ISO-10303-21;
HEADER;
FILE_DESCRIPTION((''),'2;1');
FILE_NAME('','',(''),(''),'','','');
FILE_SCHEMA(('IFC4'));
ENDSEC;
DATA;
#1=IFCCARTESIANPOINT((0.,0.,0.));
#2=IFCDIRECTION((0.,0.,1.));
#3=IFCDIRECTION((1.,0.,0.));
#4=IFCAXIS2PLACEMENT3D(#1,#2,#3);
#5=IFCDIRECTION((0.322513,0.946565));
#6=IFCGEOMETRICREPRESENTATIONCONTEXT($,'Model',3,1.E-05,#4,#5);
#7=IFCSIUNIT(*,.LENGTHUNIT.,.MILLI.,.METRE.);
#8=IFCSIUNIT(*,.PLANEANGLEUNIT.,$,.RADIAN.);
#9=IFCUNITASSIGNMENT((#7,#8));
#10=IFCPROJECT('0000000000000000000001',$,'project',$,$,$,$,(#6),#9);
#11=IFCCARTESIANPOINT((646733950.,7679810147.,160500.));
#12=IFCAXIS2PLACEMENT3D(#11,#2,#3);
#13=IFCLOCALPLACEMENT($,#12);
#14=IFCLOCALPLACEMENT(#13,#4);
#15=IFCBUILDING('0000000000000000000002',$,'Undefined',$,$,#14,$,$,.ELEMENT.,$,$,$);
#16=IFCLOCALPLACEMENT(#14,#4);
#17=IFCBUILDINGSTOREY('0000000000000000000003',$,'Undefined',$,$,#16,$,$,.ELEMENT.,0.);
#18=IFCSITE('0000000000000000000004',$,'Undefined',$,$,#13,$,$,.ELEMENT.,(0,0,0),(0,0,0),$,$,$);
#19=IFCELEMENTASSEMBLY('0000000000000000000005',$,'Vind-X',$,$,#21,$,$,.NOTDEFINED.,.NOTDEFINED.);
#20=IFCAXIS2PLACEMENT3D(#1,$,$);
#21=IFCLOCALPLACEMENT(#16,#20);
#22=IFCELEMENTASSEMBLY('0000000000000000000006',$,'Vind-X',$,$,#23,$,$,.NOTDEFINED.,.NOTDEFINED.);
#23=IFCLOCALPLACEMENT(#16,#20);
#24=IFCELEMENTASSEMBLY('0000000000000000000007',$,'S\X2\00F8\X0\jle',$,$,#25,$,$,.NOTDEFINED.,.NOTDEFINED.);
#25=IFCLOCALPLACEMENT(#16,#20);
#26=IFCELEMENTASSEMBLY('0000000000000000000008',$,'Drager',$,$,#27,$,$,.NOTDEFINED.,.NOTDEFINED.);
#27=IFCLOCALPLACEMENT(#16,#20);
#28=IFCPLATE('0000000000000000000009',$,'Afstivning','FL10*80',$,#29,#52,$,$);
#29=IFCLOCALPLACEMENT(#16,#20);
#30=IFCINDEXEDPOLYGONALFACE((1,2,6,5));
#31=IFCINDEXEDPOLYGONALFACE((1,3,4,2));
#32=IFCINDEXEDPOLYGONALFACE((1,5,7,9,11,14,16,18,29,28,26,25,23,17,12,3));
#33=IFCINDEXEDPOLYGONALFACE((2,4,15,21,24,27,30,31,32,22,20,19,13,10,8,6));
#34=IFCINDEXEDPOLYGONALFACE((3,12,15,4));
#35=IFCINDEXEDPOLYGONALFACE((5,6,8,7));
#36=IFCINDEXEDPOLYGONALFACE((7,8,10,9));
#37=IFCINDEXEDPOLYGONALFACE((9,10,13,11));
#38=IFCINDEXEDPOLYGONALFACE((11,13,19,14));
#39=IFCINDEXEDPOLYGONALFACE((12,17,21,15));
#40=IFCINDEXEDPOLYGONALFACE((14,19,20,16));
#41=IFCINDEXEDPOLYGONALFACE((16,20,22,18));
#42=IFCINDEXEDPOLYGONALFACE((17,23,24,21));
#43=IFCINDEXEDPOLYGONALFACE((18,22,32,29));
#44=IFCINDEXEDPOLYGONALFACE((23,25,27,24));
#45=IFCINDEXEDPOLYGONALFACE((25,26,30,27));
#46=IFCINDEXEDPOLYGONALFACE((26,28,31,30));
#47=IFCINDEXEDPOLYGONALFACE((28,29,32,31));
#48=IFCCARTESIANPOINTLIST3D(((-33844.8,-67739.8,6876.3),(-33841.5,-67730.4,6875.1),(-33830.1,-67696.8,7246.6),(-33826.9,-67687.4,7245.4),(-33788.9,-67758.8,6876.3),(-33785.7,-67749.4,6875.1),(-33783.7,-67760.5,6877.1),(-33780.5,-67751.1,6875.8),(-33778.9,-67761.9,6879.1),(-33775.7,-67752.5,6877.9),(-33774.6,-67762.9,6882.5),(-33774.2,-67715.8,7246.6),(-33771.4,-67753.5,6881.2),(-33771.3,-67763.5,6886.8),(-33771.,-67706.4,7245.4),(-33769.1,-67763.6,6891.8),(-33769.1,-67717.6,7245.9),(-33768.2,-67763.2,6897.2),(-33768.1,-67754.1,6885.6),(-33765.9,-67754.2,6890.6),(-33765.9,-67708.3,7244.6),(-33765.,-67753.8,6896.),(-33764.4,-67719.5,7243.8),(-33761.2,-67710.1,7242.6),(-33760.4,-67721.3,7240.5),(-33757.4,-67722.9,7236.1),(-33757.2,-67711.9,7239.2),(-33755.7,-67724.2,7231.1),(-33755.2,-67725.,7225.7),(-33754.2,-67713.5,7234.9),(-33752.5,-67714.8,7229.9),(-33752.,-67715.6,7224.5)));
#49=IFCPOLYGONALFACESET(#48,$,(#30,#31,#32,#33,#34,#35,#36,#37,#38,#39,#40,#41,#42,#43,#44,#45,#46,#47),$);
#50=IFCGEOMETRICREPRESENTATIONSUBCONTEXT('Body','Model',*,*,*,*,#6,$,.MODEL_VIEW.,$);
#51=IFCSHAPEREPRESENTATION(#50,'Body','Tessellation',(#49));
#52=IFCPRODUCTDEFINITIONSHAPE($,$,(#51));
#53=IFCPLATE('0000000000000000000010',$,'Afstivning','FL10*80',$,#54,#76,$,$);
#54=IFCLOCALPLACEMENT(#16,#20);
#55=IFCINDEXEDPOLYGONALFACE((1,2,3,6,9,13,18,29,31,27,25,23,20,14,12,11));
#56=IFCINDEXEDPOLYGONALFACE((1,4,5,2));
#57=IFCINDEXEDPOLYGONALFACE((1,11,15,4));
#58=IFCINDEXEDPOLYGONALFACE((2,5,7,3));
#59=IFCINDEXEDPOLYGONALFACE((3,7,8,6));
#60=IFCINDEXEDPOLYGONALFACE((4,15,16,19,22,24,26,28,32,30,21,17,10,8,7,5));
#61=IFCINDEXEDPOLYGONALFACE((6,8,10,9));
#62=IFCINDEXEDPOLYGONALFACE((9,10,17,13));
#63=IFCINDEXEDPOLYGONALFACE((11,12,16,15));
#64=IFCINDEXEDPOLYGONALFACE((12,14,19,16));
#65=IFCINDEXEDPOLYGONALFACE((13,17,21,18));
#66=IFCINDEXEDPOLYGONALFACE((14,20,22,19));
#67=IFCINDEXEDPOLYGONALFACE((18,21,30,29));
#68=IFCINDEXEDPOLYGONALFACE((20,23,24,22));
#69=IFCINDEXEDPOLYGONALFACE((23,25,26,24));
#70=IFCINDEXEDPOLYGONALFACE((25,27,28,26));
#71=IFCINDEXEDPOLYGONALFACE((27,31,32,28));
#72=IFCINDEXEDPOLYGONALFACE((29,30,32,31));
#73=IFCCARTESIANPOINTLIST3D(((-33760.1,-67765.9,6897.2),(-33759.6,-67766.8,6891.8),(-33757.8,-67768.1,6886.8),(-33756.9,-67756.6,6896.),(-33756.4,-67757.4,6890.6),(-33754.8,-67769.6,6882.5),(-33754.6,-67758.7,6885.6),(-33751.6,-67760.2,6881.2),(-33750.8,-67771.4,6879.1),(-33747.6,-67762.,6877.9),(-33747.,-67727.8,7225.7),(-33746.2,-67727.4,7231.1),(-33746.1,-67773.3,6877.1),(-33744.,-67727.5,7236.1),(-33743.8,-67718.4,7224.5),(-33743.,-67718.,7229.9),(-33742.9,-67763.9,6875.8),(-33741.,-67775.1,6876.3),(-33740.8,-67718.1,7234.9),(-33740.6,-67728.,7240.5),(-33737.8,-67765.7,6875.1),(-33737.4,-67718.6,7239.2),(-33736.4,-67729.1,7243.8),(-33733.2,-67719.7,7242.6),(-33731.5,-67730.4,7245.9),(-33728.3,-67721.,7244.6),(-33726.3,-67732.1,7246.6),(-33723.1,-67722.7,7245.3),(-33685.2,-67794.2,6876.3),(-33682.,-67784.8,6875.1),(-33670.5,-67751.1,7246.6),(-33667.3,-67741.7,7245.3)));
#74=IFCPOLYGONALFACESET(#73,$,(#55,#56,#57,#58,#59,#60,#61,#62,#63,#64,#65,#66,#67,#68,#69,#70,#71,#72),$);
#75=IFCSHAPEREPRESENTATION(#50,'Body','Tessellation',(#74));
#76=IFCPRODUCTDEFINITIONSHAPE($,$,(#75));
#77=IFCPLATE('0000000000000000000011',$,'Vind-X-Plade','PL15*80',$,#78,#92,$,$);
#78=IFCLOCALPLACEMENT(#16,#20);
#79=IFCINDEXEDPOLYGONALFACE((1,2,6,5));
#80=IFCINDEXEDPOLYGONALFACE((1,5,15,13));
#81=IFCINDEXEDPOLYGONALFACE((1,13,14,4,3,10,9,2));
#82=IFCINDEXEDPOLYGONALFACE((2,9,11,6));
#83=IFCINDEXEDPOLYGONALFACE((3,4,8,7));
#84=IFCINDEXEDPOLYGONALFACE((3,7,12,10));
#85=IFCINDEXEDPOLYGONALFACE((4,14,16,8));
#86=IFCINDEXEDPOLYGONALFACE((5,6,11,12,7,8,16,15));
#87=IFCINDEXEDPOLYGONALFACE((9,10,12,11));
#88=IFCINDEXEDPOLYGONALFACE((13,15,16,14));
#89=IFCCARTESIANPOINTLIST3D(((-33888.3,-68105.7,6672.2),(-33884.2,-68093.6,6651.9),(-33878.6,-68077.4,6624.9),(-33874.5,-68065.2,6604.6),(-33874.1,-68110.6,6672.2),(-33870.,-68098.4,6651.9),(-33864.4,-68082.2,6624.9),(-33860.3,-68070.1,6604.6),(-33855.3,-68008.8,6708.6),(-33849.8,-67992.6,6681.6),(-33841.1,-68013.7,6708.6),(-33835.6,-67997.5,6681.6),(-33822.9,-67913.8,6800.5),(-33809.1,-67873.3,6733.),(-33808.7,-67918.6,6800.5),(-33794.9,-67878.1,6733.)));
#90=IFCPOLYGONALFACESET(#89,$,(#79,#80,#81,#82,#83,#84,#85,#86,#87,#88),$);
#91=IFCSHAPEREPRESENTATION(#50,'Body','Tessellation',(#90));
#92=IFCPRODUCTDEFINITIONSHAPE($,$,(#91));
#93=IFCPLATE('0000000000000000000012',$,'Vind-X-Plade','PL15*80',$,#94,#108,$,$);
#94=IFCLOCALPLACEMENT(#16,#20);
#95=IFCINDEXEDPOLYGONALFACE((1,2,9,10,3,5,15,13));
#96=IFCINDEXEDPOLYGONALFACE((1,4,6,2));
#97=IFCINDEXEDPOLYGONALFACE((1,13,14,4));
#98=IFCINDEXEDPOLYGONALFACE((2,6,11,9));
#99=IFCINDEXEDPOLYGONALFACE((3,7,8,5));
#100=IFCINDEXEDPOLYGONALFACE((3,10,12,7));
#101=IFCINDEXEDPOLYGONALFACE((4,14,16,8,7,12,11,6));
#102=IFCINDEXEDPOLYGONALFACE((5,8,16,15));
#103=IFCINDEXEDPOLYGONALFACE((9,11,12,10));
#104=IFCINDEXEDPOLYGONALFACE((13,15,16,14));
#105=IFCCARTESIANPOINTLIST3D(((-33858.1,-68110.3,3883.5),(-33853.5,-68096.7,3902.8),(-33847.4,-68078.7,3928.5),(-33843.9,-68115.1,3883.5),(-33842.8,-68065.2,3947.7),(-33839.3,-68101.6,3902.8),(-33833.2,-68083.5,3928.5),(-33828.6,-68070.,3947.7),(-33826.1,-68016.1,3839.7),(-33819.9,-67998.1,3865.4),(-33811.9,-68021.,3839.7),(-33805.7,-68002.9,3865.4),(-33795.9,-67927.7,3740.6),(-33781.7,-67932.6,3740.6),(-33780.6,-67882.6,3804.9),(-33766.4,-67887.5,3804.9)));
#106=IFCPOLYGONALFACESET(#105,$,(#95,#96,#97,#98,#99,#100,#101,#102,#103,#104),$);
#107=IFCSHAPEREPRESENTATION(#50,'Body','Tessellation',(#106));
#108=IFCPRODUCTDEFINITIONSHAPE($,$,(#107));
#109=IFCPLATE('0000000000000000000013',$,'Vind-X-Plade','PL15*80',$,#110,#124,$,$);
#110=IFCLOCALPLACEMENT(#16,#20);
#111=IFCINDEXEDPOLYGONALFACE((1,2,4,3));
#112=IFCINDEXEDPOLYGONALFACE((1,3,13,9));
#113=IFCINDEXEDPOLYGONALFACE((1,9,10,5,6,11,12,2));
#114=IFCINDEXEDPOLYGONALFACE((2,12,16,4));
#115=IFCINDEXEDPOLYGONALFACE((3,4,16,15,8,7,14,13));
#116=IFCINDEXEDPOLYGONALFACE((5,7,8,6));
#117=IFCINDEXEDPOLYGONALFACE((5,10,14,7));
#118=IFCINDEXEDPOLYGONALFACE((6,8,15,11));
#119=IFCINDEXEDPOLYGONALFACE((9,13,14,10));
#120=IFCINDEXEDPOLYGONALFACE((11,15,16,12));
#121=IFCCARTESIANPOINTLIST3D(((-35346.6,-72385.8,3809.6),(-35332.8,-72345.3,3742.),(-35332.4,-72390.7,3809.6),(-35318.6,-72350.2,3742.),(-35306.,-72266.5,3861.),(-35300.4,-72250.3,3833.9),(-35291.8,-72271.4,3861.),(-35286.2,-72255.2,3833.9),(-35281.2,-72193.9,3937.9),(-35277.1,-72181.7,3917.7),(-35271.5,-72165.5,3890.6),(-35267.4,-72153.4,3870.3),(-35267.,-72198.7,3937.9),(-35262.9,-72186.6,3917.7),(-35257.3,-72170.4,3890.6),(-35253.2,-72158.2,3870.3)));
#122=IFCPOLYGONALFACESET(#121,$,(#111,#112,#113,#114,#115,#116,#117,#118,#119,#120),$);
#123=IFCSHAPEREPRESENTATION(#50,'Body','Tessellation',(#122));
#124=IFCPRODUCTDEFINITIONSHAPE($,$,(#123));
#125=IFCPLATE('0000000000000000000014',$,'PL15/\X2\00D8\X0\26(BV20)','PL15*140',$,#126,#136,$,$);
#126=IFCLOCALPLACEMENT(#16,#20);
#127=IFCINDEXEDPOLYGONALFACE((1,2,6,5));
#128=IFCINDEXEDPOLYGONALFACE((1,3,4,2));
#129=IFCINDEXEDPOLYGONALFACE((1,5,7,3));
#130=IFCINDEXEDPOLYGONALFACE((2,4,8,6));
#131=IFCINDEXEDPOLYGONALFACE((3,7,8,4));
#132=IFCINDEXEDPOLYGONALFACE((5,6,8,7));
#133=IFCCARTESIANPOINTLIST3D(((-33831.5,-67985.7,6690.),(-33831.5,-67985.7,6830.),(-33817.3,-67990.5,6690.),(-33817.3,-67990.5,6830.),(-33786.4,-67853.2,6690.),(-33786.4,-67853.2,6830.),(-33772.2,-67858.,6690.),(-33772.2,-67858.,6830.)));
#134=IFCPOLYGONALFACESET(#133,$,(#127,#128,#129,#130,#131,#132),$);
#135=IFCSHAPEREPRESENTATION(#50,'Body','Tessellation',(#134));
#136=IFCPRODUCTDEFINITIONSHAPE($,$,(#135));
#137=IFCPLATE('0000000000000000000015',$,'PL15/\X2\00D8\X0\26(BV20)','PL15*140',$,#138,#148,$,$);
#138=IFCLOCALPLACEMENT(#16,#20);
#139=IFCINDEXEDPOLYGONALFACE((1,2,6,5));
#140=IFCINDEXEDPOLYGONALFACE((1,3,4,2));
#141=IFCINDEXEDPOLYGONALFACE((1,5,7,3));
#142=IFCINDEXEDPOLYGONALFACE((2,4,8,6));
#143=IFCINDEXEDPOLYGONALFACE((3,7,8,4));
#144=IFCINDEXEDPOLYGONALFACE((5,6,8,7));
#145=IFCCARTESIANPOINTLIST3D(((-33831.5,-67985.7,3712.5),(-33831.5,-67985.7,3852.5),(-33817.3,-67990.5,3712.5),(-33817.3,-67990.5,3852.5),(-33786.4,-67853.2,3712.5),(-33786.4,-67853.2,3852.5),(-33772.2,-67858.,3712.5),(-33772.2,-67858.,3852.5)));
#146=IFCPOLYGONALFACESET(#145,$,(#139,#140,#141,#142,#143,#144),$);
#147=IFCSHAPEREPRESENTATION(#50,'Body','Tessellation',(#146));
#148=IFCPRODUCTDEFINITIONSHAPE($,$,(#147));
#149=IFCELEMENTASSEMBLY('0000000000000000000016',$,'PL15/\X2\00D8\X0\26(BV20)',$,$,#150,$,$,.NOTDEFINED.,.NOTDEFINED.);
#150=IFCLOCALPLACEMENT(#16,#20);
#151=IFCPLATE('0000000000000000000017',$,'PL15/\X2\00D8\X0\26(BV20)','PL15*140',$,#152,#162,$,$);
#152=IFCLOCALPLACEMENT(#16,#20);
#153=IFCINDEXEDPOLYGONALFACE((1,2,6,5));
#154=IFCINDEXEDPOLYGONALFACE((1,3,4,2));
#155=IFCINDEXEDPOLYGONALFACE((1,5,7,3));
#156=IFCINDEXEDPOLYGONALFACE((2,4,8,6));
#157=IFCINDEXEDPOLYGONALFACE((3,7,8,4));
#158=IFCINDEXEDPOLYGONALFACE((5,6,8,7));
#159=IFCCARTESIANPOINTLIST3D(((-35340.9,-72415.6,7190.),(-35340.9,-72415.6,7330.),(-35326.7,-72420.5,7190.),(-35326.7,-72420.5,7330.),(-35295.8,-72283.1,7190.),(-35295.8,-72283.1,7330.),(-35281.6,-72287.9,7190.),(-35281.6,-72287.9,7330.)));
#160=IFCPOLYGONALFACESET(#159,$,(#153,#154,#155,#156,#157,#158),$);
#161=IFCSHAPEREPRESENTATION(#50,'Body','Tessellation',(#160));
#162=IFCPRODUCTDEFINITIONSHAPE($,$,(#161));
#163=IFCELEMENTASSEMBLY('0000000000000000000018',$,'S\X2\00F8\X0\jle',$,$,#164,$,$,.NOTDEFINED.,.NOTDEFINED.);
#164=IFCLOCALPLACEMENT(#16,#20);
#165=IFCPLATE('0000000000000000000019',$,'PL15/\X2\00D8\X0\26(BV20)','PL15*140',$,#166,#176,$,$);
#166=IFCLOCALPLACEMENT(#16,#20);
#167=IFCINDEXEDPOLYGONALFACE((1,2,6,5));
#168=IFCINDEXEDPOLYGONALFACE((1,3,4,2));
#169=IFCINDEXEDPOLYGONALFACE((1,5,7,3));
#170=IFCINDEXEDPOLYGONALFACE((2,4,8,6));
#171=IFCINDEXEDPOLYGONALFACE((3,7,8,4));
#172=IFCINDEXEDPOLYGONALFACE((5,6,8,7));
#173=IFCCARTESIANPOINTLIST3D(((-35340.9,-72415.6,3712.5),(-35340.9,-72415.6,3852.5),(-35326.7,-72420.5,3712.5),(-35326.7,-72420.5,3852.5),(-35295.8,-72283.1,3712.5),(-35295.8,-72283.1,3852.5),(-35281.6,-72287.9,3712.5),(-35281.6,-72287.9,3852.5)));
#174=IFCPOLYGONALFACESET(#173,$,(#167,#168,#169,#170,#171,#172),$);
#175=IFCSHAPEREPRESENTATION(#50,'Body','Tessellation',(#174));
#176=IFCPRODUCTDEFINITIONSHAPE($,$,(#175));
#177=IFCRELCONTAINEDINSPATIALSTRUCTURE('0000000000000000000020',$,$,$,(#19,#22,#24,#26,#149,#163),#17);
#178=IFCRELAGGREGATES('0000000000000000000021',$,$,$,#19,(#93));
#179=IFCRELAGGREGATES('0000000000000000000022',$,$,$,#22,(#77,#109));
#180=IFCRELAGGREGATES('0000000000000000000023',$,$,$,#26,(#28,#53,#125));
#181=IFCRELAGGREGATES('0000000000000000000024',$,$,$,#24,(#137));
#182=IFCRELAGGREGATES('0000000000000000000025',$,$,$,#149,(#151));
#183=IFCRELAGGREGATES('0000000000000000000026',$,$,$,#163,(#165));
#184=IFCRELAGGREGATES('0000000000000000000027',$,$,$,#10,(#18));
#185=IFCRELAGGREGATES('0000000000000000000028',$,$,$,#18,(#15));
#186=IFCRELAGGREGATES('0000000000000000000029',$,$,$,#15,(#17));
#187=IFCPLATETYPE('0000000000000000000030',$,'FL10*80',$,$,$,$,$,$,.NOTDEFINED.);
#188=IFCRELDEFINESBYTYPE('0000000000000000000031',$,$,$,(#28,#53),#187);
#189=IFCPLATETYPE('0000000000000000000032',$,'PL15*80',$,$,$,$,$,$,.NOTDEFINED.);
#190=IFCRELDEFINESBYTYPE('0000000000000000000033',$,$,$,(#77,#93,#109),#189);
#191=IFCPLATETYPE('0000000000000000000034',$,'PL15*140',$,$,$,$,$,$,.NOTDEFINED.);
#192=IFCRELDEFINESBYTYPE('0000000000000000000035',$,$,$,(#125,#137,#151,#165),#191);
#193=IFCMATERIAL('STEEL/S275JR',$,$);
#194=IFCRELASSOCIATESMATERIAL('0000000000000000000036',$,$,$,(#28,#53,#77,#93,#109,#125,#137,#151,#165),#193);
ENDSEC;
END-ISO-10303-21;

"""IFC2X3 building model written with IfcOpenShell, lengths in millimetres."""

from ifc_helpers import new_model, si_unit, direction, frame, frame_2d, origin_with_axes, place, context, subcontext, project, spatial, polyline, circle_curve, parameter, trimmed, segment, composite_curve, outline, extrude, boolean, material, type_object, element, aggregate, save


model = new_model("IFC2X3")

# Units and contexts
model_context = context("Model", 3, precision=1e-05, world=origin_with_axes(), true_north=direction((0.322513, 0.946565)))
body_context = subcontext(model_context, "Body", "Model", "MODEL_VIEW")
ifc_project = project(units=[si_unit("LENGTHUNIT", "METRE", prefix="MILLI"), si_unit("PLANEANGLEUNIT", "RADIAN")], contexts=[model_context])

# Site, building, storey
site_placement = place(None, frame((646733950.0, 7679810147.0, 160500.0), z_axis=(0.0, 0.0, 1.0), x_axis=(1.0, 0.0, 0.0)))
site = spatial("IfcSite", under=ifc_project, at=site_placement, Name="Undefined", CompositionType="ELEMENT", RefLatitude=(0, 0, 0), RefLongitude=(0, 0, 0))
building_placement = place(site_placement, origin_with_axes())
building = spatial("IfcBuilding", under=site, at=building_placement, Name="Undefined", CompositionType="ELEMENT")
storey_placement = place(building_placement, origin_with_axes())
storey = spatial("IfcBuildingStorey", under=building, at=storey_placement, Name="Undefined", CompositionType="ELEMENT", Elevation=0.0)

# Element assemblies
assembly_1_placement = place(storey_placement, origin_with_axes())
assembly_1 = element("IfcElementAssembly", 1, at=assembly_1_placement, inside=storey, Name="Vind-X", AssemblyPlace="NOTDEFINED", PredefinedType="NOTDEFINED")
assembly_2_placement = place(storey_placement, origin_with_axes())
assembly_2 = element("IfcElementAssembly", 2, at=assembly_2_placement, inside=storey, Name="Vind-X", AssemblyPlace="NOTDEFINED", PredefinedType="NOTDEFINED")

# Element assembly
assembly_3_placement = place(storey_placement, origin_with_axes())
assembly_3 = element("IfcElementAssembly", 3, at=assembly_3_placement, inside=storey, Name="Søjle", AssemblyPlace="NOTDEFINED", PredefinedType="NOTDEFINED")
ifc_material_1 = material(Name="STEEL/S275JR")

# Element assembly, plates
assembly_4_placement = place(storey_placement, origin_with_axes())
assembly_4 = element("IfcElementAssembly", 4, at=assembly_4_placement, inside=storey, Name="Drager", AssemblyPlace="NOTDEFINED", PredefinedType="NOTDEFINED")
plate_type_1 = type_object("IfcPlateType", Name="FL10*80", PredefinedType="NOTDEFINED")
plate_1_placement = place(assembly_4_placement, frame((-33767.4, -67760.9, 6875.7), z_axis=(0.320109, 0.93951, -0.121869), x_axis=(-0.946565, 0.322513, 0.0)))
plate_1 = element("IfcPlate", 5, at=plate_1_placement, type_object=plate_type_1, material=ifc_material_1, Name="Afstivning", Description="FL10*80", context=body_context, shape_type="SweptSolid", body=[
    extrude(outline(composite_curve([segment(trimmed(circle_curve(frame_2d((21.0, 21.0), x_axis=(-1.0, 0.0)), 21.0), [parameter(0.0)], [parameter(1.570796)], True, "PARAMETER"), True, "CONTINUOUS"), segment(polyline([(21.0, 0.0), (80.0, 0.0), (80.0, 373.0), (21.0, 373.0)]), True, "CONTINUOUS"), segment(trimmed(circle_curve(frame_2d((21.0, 352.0), x_axis=(0.0, 1.0)), 21.0), [parameter(0.0)], [parameter(1.570796)], True, "PARAMETER"), True, "CONTINUOUS"), segment(polyline([(0.0, 352.0), (0.0, 21.0)]), True, "CONTINUOUS")], self_intersect=True)), frame((0.0, 0.0, -5.0), z_axis=(0.0, 0.0, 1.0), x_axis=(1.0, 0.0, 0.0)), (0.0, 0.0, 1.0), 10.0),
])
plate_2_placement = place(assembly_4_placement, frame((-33683.6, -67789.5, 6875.7), z_axis=(0.320109, 0.93951, -0.121869), x_axis=(-0.946565, 0.322513, 0.0)))
plate_2 = element("IfcPlate", 6, at=plate_2_placement, type_object=plate_type_1, material=ifc_material_1, Name="Afstivning", Description="FL10*80", context=body_context, shape_type="SweptSolid", body=[
    extrude(outline(composite_curve([segment(polyline([(0.0, 0.0), (59.0, 0.0)]), True, "CONTINUOUS"), segment(trimmed(circle_curve(frame_2d((59.0, 21.0), x_axis=(0.0, -1.0)), 21.0), [parameter(0.0)], [parameter(1.570796)], True, "PARAMETER"), True, "CONTINUOUS"), segment(polyline([(80.0, 21.0), (80.0, 352.0)]), True, "CONTINUOUS"), segment(trimmed(circle_curve(frame_2d((59.0, 352.0), x_axis=(1.0, 0.0)), 21.0), [parameter(0.0)], [parameter(1.570796)], True, "PARAMETER"), True, "CONTINUOUS"), segment(polyline([(59.0, 373.0), (0.0, 373.0), (0.0, 0.0)]), True, "CONTINUOUS")], self_intersect=True)), frame((0.0, 0.0, -5.0), z_axis=(0.0, 0.0, 1.0), x_axis=(1.0, 0.0, 0.0)), (0.0, 0.0, 1.0), 10.0),
])

# Plates
plate_type_2 = type_object("IfcPlateType", Name="PL15*80", PredefinedType="NOTDEFINED")
plate_3_placement = place(assembly_2_placement, frame((-33802.0, -67875.7, 6733.0), z_axis=(0.946565, -0.322513, 0.0), x_axis=(-0.172512, -0.506318, 0.844915)))
plate_3 = element("IfcPlate", 7, at=plate_3_placement, type_object=plate_type_2, material=ifc_material_1, Name="Vind-X-Plade", Description="PL15*80", context=body_context, shape_type="CSG", body=[
    boolean("DIFFERENCE", extrude(outline(polyline([(0.0, 0.0), (80.0, 0.0), (80.0, 240.0), (0.0, 240.0), (0.0, 0.0)])), frame((0.0, 0.0, -7.5), z_axis=(0.0, 0.0, 1.0), x_axis=(1.0, 0.0, 0.0)), (0.0, 0.0, 1.0), 15.0), extrude(outline(polyline([(0.0, 0.0), (106.0, 0.0), (106.0, 32.0), (0.0, 32.0), (0.0, 0.0)])), frame((56.0, 240.0, 8.5), z_axis=(0.0, 0.0, -1.0), x_axis=(0.0, -1.0, 0.0)), (0.0, 0.0, 1.0), 17.0)),
])
plate_4_placement = place(assembly_1_placement, frame((-33788.8, -67930.1, 3740.6), z_axis=(0.946565, -0.322513, 0.0), x_axis=(0.191985, 0.563471, 0.803519)))
plate_4 = element("IfcPlate", 8, at=plate_4_placement, type_object=plate_type_2, material=ifc_material_1, Name="Vind-X-Plade", Description="PL15*80", context=body_context, shape_type="CSG", body=[
    boolean("DIFFERENCE", extrude(outline(polyline([(0.0, 0.0), (80.0, 0.0), (80.0, 240.0), (0.0, 240.0), (0.0, 0.0)])), frame((0.0, 0.0, -7.5), z_axis=(0.0, 0.0, 1.0), x_axis=(1.0, 0.0, 0.0)), (0.0, 0.0, 1.0), 15.0), extrude(outline(polyline([(0.0, 0.0), (106.0, 0.0), (106.0, 32.0), (0.0, 32.0), (0.0, 0.0)])), frame((56.0, 240.0, 8.5), z_axis=(0.0, 0.0, -1.0), x_axis=(0.0, -1.0, 0.0)), (0.0, 0.0, 1.0), 17.0)),
])
plate_5_placement = place(assembly_2_placement, frame((-35325.7, -72347.8, 3742.0), z_axis=(-0.946565, 0.322513, 0.0), x_axis=(-0.172512, -0.506318, 0.844915)))
plate_5 = element("IfcPlate", 9, at=plate_5_placement, type_object=plate_type_2, material=ifc_material_1, Name="Vind-X-Plade", Description="PL15*80", context=body_context, shape_type="CSG", body=[
    boolean("DIFFERENCE", extrude(outline(polyline([(0.0, 0.0), (80.0, 0.0), (80.0, 240.0), (0.0, 240.0), (0.0, 0.0)])), frame((0.0, 0.0, -7.5), z_axis=(0.0, 0.0, 1.0), x_axis=(1.0, 0.0, 0.0)), (0.0, 0.0, 1.0), 15.0), extrude(outline(polyline([(0.0, 0.0), (106.0, 0.0), (106.0, 32.0), (0.0, 32.0), (0.0, 0.0)])), frame((56.0, 240.0, 8.5), z_axis=(0.0, 0.0, -1.0), x_axis=(0.0, -1.0, 0.0)), (0.0, 0.0, 1.0), 17.0)),
])
plate_type_3 = type_object("IfcPlateType", Name="PL15*140", PredefinedType="NOTDEFINED")
plate_6_placement = place(assembly_4_placement, frame((-33779.3, -67855.6, 6690.0), z_axis=(-0.946565, 0.322513, 0.0), x_axis=(-0.322513, -0.946565, 0.0)))
plate_6 = element("IfcPlate", 10, at=plate_6_placement, type_object=plate_type_3, material=ifc_material_1, Name="PL15/Ø26(BV20)", Description="PL15*140", context=body_context, shape_type="SweptSolid", body=[
    extrude(outline(polyline([(0.0, 0.0), (140.0, 0.0), (140.0, 140.0), (0.0, 140.0), (0.0, 0.0)])), frame((0.0, 0.0, -7.5), z_axis=(0.0, 0.0, 1.0), x_axis=(1.0, 0.0, 0.0)), (0.0, 0.0, 1.0), 15.0),
])
plate_7_placement = place(assembly_3_placement, frame((-33779.3, -67855.6, 3712.5), z_axis=(-0.946565, 0.322513, 0.0), x_axis=(-0.322513, -0.946565, 0.0)))
plate_7 = element("IfcPlate", 11, at=plate_7_placement, type_object=plate_type_3, material=ifc_material_1, Name="PL15/Ø26(BV20)", Description="PL15*140", context=body_context, shape_type="SweptSolid", body=[
    extrude(outline(polyline([(0.0, 0.0), (140.0, 0.0), (140.0, 140.0), (0.0, 140.0), (0.0, 0.0)])), frame((0.0, 0.0, -7.5), z_axis=(0.0, 0.0, 1.0), x_axis=(1.0, 0.0, 0.0)), (0.0, 0.0, 1.0), 15.0),
])

# Element assemblies, plates
assembly_5_placement = place(storey_placement, origin_with_axes())
assembly_5 = element("IfcElementAssembly", 12, at=assembly_5_placement, inside=storey, Name="PL15/Ø26(BV20)", AssemblyPlace="NOTDEFINED", PredefinedType="NOTDEFINED")
plate_8_placement = place(assembly_5_placement, frame((-35288.7, -72285.5, 7190.0), z_axis=(-0.946565, 0.322513, 0.0), x_axis=(-0.322513, -0.946565, 0.0)))
plate_8 = element("IfcPlate", 13, at=plate_8_placement, type_object=plate_type_3, material=ifc_material_1, Name="PL15/Ø26(BV20)", Description="PL15*140", context=body_context, shape_type="SweptSolid", body=[
    extrude(outline(polyline([(0.0, 0.0), (140.0, 0.0), (140.0, 140.0), (0.0, 140.0), (0.0, 0.0)])), frame((0.0, 0.0, -7.5), z_axis=(0.0, 0.0, 1.0), x_axis=(1.0, 0.0, 0.0)), (0.0, 0.0, 1.0), 15.0),
])
assembly_6_placement = place(storey_placement, origin_with_axes())
assembly_6 = element("IfcElementAssembly", 14, at=assembly_6_placement, inside=storey, Name="Søjle", AssemblyPlace="NOTDEFINED", PredefinedType="NOTDEFINED")
plate_9_placement = place(assembly_6_placement, frame((-35288.7, -72285.5, 3712.5), z_axis=(-0.946565, 0.322513, 0.0), x_axis=(-0.322513, -0.946565, 0.0)))
plate_9 = element("IfcPlate", 15, at=plate_9_placement, type_object=plate_type_3, material=ifc_material_1, Name="PL15/Ø26(BV20)", Description="PL15*140", context=body_context, shape_type="SweptSolid", body=[
    extrude(outline(polyline([(0.0, 0.0), (140.0, 0.0), (140.0, 140.0), (0.0, 140.0), (0.0, 0.0)])), frame((0.0, 0.0, -7.5), z_axis=(0.0, 0.0, 1.0), x_axis=(1.0, 0.0, 0.0)), (0.0, 0.0, 1.0), 15.0),
])

aggregate(assembly_1, [plate_4])
aggregate(assembly_2, [plate_3, plate_5])
aggregate(assembly_4, [plate_1, plate_2, plate_6])
aggregate(assembly_3, [plate_7])
aggregate(assembly_5, [plate_8])
aggregate(assembly_6, [plate_9])

save(model, "model.ifc")
